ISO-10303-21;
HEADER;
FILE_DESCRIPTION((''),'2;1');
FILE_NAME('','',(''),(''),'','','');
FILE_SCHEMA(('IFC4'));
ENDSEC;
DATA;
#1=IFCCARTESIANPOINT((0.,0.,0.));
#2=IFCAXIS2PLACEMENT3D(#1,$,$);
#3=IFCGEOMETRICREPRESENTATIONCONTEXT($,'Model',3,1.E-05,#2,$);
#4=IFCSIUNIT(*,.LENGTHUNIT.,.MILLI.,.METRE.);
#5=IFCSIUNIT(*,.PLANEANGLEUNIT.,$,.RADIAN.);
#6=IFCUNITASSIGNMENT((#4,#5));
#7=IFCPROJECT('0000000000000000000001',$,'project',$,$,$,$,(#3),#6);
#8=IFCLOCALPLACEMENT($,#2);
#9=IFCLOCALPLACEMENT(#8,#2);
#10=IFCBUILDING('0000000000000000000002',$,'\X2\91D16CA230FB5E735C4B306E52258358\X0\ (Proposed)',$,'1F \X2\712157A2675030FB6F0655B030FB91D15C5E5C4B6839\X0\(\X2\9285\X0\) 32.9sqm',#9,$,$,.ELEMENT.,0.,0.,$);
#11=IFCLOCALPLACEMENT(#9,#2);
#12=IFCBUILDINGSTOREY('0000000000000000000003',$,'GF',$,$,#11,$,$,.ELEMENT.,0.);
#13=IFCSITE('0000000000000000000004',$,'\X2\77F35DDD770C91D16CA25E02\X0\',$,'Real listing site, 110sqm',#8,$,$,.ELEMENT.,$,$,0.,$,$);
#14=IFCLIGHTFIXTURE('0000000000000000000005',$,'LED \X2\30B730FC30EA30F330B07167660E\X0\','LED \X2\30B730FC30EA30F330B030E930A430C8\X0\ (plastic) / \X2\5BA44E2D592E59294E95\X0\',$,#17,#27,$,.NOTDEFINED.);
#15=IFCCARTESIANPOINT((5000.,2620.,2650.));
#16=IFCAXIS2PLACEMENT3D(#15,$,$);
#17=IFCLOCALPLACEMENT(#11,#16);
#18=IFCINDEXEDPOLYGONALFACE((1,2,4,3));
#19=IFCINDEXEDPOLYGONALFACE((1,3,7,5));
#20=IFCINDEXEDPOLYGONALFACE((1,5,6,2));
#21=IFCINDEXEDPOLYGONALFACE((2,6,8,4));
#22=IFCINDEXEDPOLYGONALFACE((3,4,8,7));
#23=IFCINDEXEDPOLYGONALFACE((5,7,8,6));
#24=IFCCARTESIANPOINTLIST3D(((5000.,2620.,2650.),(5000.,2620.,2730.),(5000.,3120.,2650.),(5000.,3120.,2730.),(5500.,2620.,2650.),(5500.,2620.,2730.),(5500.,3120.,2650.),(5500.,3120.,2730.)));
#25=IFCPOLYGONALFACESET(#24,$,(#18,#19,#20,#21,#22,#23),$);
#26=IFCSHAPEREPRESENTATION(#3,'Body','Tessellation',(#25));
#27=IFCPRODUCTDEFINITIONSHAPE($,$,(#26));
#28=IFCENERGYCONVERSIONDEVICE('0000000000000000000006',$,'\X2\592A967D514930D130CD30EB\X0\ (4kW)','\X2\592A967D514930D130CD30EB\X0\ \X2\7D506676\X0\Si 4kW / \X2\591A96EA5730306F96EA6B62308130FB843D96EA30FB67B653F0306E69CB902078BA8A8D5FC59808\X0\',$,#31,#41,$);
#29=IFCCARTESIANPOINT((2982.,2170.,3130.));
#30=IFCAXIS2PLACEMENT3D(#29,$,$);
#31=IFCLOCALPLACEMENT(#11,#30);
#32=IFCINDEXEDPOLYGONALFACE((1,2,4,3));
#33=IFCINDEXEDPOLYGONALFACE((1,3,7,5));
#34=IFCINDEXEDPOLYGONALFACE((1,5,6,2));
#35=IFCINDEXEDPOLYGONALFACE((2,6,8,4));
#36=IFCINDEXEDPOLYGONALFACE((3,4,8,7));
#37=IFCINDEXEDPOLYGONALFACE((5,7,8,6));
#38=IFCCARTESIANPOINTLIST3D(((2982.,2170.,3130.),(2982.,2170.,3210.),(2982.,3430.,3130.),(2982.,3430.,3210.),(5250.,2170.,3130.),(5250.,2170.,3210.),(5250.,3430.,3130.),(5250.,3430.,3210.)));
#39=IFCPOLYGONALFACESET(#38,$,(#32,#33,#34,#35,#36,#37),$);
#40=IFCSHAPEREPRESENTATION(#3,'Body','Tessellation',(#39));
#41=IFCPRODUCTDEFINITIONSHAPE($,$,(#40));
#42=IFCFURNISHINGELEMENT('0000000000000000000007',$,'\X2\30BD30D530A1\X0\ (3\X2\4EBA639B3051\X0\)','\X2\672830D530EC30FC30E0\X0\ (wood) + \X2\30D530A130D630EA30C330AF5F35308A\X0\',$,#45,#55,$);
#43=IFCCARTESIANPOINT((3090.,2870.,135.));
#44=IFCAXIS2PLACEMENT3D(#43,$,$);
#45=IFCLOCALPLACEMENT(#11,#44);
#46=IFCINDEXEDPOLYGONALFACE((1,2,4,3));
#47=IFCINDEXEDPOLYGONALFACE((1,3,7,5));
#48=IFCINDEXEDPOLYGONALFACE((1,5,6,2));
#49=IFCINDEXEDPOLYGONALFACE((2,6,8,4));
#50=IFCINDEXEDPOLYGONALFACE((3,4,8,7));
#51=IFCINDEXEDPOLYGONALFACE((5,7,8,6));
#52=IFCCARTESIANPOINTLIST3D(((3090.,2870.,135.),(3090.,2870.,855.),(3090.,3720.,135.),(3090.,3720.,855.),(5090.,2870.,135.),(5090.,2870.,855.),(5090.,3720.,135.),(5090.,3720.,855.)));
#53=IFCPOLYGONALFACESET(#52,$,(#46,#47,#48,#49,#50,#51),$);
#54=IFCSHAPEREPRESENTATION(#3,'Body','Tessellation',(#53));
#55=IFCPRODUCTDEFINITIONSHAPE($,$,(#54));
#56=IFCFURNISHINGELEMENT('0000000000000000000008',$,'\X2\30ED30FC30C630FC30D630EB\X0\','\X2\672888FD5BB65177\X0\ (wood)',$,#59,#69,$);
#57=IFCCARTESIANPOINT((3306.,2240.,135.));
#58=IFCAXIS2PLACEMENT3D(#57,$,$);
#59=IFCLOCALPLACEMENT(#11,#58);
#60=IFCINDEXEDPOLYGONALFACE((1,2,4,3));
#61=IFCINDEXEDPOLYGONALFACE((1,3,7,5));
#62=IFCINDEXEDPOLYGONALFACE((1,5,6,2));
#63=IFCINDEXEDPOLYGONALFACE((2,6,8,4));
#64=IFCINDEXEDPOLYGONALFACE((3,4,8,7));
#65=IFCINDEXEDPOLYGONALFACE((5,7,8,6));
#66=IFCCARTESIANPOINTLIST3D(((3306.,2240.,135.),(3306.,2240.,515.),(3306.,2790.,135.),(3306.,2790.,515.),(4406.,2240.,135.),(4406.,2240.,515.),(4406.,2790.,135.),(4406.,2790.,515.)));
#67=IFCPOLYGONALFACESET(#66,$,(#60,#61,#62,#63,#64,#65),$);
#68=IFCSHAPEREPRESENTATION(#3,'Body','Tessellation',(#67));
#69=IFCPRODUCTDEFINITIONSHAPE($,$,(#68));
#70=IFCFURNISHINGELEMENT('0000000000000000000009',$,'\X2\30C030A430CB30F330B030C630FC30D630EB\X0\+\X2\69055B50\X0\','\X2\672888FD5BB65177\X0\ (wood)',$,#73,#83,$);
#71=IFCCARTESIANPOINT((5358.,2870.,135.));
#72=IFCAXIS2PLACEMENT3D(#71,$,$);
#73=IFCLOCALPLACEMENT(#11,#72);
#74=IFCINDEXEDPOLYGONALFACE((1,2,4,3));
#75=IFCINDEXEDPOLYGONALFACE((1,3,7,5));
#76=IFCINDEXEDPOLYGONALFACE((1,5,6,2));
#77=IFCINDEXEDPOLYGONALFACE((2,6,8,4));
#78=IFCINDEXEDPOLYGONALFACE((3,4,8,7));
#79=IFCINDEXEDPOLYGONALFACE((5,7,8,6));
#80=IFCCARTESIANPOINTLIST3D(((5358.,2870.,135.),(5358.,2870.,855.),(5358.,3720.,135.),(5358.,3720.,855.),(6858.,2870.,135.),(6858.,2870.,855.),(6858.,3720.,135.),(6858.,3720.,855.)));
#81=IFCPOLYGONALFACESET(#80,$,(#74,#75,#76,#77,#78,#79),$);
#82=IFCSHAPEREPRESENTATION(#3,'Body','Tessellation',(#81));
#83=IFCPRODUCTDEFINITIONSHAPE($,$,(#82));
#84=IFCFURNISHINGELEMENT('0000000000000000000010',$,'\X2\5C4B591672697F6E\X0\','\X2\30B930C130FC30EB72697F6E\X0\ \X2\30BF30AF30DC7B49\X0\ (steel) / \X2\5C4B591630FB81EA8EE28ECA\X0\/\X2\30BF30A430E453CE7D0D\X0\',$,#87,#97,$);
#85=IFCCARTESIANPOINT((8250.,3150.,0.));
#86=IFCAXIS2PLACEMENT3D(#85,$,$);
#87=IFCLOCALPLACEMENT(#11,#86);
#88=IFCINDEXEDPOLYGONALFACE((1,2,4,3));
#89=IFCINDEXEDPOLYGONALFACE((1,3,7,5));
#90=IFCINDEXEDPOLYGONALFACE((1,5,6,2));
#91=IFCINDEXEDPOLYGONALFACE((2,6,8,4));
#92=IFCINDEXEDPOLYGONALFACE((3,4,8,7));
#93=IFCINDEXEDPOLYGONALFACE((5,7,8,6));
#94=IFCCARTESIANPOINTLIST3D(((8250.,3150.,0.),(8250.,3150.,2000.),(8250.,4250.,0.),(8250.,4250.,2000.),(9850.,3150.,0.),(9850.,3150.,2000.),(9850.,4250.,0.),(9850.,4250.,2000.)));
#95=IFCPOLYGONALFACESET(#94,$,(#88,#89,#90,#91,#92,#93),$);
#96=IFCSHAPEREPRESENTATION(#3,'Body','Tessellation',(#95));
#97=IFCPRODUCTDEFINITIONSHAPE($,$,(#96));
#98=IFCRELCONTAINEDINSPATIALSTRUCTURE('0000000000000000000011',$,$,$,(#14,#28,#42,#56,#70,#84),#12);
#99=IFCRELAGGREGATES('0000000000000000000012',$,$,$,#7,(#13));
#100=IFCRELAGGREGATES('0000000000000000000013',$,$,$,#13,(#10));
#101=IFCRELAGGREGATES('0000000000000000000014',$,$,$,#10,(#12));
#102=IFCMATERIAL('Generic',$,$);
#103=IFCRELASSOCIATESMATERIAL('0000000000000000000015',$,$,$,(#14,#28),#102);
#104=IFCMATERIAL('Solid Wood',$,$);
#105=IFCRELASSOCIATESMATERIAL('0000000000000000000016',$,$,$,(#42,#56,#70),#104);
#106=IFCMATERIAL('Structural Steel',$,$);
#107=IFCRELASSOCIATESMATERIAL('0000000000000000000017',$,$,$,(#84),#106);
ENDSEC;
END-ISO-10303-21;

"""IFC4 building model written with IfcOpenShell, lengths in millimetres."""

from ifc_helpers import new_model, si_unit, frame, frame_2d, origin, place, context, project, spatial, rectangle, extrude, material, element, save


model = new_model("IFC4")

# Units and contexts
model_context = context("Model", 3, precision=1e-05, world=origin())
ifc_project = project(units=[si_unit("LENGTHUNIT", "METRE", prefix="MILLI"), si_unit("PLANEANGLEUNIT", "RADIAN")], contexts=[model_context])

# Site, building, storey
site_placement = place(None, origin())
site = spatial("IfcSite", under=ifc_project, at=site_placement, Name="石川県金沢市", ObjectType="Real listing site, 110sqm", CompositionType="ELEMENT", RefElevation=0.0)
building_placement = place(site_placement, origin())
building = spatial("IfcBuilding", under=site, at=building_placement, Name="金沢・平屋の別荘 (Proposed)", ObjectType="1F 無垢材・漆喰・金属屋根(銅) 32.9sqm", CompositionType="ELEMENT", ElevationOfRefHeight=0.0, ElevationOfTerrain=0.0)
storey_placement = place(building_placement, origin())
storey = spatial("IfcBuildingStorey", under=building, at=storey_placement, Name="GF", CompositionType="ELEMENT", Elevation=0.0)

# Shared definitions
ifc_material_1 = material(Name="Solid Wood")

# Shared definitions
ifc_material_2 = material(Name="Structural Steel")

# Light fixture
ifc_material_3 = material(Name="Generic")
light_fixture_placement = place(storey_placement, frame((5000.0, 2620.0, 2650.0)))
element("IfcLightFixture", 1, at=light_fixture_placement, inside=storey, material=ifc_material_3, Name="LED シーリング照明", Description="LED シーリングライト (plastic) / 室中央天井", PredefinedType="NOTDEFINED", context=model_context, shape_type="SweptSolid", body=[
    extrude(rectangle(XDim=500.0, YDim=500.0, at=frame_2d((250.0, 250.0))), frame((5000.0, 2620.0, 2650.0)), (0.0, 0.0, 1.0), 80.0),
])

# Energy conversion device
energy_conversion_device_placement = place(storey_placement, frame((2982.0, 2170.0, 3130.0)))
element("IfcEnergyConversionDevice", 2, at=energy_conversion_device_placement, inside=storey, material=ifc_material_3, Name="太陽光パネル (4kW)", Description="太陽光パネル 結晶Si 4kW / 多雪地は雪止め・落雪・架台の構造確認必須", context=model_context, shape_type="SweptSolid", body=[
    extrude(rectangle(XDim=2268.0, YDim=1260.0, at=frame_2d((1134.0, 630.0))), frame((2982.0, 2170.0, 3130.0)), (0.0, 0.0, 1.0), 80.0),
])

# Furnishing elements
furnishing_1_placement = place(storey_placement, frame((3090.0, 2870.0, 135.0)))
element("IfcFurnishingElement", 3, at=furnishing_1_placement, inside=storey, material=ifc_material_1, Name="ソファ (3人掛け)", Description="木フレーム (wood) + ファブリック張り", context=model_context, shape_type="SweptSolid", body=[
    extrude(rectangle(XDim=2000.0, YDim=850.0, at=frame_2d((1000.0, 425.0))), frame((3090.0, 2870.0, 135.0)), (0.0, 0.0, 1.0), 720.0),
])
furnishing_2_placement = place(storey_placement, frame((3306.0, 2240.0, 135.0)))
element("IfcFurnishingElement", 4, at=furnishing_2_placement, inside=storey, material=ifc_material_1, Name="ローテーブル", Description="木製家具 (wood)", context=model_context, shape_type="SweptSolid", body=[
    extrude(rectangle(XDim=1100.0, YDim=550.0, at=frame_2d((550.0, 275.0))), frame((3306.0, 2240.0, 135.0)), (0.0, 0.0, 1.0), 380.0),
])
furnishing_3_placement = place(storey_placement, frame((5358.0, 2870.0, 135.0)))
element("IfcFurnishingElement", 5, at=furnishing_3_placement, inside=storey, material=ifc_material_1, Name="ダイニングテーブル+椅子", Description="木製家具 (wood)", context=model_context, shape_type="SweptSolid", body=[
    extrude(rectangle(XDim=1500.0, YDim=850.0, at=frame_2d((750.0, 425.0))), frame((5358.0, 2870.0, 135.0)), (0.0, 0.0, 1.0), 720.0),
])
furnishing_4_placement = place(storey_placement, frame((8250.0, 3150.0, 0.0)))
element("IfcFurnishingElement", 6, at=furnishing_4_placement, inside=storey, material=ifc_material_2, Name="屋外物置", Description="スチール物置 タクボ等 (steel) / 屋外・自転車/タイヤ収納", context=model_context, shape_type="SweptSolid", body=[
    extrude(rectangle(XDim=1600.0, YDim=1100.0, at=frame_2d((800.0, 550.0))), frame((8250.0, 3150.0, 0.0)), (0.0, 0.0, 1.0), 2000.0),
])

save(model, "model.ifc")
